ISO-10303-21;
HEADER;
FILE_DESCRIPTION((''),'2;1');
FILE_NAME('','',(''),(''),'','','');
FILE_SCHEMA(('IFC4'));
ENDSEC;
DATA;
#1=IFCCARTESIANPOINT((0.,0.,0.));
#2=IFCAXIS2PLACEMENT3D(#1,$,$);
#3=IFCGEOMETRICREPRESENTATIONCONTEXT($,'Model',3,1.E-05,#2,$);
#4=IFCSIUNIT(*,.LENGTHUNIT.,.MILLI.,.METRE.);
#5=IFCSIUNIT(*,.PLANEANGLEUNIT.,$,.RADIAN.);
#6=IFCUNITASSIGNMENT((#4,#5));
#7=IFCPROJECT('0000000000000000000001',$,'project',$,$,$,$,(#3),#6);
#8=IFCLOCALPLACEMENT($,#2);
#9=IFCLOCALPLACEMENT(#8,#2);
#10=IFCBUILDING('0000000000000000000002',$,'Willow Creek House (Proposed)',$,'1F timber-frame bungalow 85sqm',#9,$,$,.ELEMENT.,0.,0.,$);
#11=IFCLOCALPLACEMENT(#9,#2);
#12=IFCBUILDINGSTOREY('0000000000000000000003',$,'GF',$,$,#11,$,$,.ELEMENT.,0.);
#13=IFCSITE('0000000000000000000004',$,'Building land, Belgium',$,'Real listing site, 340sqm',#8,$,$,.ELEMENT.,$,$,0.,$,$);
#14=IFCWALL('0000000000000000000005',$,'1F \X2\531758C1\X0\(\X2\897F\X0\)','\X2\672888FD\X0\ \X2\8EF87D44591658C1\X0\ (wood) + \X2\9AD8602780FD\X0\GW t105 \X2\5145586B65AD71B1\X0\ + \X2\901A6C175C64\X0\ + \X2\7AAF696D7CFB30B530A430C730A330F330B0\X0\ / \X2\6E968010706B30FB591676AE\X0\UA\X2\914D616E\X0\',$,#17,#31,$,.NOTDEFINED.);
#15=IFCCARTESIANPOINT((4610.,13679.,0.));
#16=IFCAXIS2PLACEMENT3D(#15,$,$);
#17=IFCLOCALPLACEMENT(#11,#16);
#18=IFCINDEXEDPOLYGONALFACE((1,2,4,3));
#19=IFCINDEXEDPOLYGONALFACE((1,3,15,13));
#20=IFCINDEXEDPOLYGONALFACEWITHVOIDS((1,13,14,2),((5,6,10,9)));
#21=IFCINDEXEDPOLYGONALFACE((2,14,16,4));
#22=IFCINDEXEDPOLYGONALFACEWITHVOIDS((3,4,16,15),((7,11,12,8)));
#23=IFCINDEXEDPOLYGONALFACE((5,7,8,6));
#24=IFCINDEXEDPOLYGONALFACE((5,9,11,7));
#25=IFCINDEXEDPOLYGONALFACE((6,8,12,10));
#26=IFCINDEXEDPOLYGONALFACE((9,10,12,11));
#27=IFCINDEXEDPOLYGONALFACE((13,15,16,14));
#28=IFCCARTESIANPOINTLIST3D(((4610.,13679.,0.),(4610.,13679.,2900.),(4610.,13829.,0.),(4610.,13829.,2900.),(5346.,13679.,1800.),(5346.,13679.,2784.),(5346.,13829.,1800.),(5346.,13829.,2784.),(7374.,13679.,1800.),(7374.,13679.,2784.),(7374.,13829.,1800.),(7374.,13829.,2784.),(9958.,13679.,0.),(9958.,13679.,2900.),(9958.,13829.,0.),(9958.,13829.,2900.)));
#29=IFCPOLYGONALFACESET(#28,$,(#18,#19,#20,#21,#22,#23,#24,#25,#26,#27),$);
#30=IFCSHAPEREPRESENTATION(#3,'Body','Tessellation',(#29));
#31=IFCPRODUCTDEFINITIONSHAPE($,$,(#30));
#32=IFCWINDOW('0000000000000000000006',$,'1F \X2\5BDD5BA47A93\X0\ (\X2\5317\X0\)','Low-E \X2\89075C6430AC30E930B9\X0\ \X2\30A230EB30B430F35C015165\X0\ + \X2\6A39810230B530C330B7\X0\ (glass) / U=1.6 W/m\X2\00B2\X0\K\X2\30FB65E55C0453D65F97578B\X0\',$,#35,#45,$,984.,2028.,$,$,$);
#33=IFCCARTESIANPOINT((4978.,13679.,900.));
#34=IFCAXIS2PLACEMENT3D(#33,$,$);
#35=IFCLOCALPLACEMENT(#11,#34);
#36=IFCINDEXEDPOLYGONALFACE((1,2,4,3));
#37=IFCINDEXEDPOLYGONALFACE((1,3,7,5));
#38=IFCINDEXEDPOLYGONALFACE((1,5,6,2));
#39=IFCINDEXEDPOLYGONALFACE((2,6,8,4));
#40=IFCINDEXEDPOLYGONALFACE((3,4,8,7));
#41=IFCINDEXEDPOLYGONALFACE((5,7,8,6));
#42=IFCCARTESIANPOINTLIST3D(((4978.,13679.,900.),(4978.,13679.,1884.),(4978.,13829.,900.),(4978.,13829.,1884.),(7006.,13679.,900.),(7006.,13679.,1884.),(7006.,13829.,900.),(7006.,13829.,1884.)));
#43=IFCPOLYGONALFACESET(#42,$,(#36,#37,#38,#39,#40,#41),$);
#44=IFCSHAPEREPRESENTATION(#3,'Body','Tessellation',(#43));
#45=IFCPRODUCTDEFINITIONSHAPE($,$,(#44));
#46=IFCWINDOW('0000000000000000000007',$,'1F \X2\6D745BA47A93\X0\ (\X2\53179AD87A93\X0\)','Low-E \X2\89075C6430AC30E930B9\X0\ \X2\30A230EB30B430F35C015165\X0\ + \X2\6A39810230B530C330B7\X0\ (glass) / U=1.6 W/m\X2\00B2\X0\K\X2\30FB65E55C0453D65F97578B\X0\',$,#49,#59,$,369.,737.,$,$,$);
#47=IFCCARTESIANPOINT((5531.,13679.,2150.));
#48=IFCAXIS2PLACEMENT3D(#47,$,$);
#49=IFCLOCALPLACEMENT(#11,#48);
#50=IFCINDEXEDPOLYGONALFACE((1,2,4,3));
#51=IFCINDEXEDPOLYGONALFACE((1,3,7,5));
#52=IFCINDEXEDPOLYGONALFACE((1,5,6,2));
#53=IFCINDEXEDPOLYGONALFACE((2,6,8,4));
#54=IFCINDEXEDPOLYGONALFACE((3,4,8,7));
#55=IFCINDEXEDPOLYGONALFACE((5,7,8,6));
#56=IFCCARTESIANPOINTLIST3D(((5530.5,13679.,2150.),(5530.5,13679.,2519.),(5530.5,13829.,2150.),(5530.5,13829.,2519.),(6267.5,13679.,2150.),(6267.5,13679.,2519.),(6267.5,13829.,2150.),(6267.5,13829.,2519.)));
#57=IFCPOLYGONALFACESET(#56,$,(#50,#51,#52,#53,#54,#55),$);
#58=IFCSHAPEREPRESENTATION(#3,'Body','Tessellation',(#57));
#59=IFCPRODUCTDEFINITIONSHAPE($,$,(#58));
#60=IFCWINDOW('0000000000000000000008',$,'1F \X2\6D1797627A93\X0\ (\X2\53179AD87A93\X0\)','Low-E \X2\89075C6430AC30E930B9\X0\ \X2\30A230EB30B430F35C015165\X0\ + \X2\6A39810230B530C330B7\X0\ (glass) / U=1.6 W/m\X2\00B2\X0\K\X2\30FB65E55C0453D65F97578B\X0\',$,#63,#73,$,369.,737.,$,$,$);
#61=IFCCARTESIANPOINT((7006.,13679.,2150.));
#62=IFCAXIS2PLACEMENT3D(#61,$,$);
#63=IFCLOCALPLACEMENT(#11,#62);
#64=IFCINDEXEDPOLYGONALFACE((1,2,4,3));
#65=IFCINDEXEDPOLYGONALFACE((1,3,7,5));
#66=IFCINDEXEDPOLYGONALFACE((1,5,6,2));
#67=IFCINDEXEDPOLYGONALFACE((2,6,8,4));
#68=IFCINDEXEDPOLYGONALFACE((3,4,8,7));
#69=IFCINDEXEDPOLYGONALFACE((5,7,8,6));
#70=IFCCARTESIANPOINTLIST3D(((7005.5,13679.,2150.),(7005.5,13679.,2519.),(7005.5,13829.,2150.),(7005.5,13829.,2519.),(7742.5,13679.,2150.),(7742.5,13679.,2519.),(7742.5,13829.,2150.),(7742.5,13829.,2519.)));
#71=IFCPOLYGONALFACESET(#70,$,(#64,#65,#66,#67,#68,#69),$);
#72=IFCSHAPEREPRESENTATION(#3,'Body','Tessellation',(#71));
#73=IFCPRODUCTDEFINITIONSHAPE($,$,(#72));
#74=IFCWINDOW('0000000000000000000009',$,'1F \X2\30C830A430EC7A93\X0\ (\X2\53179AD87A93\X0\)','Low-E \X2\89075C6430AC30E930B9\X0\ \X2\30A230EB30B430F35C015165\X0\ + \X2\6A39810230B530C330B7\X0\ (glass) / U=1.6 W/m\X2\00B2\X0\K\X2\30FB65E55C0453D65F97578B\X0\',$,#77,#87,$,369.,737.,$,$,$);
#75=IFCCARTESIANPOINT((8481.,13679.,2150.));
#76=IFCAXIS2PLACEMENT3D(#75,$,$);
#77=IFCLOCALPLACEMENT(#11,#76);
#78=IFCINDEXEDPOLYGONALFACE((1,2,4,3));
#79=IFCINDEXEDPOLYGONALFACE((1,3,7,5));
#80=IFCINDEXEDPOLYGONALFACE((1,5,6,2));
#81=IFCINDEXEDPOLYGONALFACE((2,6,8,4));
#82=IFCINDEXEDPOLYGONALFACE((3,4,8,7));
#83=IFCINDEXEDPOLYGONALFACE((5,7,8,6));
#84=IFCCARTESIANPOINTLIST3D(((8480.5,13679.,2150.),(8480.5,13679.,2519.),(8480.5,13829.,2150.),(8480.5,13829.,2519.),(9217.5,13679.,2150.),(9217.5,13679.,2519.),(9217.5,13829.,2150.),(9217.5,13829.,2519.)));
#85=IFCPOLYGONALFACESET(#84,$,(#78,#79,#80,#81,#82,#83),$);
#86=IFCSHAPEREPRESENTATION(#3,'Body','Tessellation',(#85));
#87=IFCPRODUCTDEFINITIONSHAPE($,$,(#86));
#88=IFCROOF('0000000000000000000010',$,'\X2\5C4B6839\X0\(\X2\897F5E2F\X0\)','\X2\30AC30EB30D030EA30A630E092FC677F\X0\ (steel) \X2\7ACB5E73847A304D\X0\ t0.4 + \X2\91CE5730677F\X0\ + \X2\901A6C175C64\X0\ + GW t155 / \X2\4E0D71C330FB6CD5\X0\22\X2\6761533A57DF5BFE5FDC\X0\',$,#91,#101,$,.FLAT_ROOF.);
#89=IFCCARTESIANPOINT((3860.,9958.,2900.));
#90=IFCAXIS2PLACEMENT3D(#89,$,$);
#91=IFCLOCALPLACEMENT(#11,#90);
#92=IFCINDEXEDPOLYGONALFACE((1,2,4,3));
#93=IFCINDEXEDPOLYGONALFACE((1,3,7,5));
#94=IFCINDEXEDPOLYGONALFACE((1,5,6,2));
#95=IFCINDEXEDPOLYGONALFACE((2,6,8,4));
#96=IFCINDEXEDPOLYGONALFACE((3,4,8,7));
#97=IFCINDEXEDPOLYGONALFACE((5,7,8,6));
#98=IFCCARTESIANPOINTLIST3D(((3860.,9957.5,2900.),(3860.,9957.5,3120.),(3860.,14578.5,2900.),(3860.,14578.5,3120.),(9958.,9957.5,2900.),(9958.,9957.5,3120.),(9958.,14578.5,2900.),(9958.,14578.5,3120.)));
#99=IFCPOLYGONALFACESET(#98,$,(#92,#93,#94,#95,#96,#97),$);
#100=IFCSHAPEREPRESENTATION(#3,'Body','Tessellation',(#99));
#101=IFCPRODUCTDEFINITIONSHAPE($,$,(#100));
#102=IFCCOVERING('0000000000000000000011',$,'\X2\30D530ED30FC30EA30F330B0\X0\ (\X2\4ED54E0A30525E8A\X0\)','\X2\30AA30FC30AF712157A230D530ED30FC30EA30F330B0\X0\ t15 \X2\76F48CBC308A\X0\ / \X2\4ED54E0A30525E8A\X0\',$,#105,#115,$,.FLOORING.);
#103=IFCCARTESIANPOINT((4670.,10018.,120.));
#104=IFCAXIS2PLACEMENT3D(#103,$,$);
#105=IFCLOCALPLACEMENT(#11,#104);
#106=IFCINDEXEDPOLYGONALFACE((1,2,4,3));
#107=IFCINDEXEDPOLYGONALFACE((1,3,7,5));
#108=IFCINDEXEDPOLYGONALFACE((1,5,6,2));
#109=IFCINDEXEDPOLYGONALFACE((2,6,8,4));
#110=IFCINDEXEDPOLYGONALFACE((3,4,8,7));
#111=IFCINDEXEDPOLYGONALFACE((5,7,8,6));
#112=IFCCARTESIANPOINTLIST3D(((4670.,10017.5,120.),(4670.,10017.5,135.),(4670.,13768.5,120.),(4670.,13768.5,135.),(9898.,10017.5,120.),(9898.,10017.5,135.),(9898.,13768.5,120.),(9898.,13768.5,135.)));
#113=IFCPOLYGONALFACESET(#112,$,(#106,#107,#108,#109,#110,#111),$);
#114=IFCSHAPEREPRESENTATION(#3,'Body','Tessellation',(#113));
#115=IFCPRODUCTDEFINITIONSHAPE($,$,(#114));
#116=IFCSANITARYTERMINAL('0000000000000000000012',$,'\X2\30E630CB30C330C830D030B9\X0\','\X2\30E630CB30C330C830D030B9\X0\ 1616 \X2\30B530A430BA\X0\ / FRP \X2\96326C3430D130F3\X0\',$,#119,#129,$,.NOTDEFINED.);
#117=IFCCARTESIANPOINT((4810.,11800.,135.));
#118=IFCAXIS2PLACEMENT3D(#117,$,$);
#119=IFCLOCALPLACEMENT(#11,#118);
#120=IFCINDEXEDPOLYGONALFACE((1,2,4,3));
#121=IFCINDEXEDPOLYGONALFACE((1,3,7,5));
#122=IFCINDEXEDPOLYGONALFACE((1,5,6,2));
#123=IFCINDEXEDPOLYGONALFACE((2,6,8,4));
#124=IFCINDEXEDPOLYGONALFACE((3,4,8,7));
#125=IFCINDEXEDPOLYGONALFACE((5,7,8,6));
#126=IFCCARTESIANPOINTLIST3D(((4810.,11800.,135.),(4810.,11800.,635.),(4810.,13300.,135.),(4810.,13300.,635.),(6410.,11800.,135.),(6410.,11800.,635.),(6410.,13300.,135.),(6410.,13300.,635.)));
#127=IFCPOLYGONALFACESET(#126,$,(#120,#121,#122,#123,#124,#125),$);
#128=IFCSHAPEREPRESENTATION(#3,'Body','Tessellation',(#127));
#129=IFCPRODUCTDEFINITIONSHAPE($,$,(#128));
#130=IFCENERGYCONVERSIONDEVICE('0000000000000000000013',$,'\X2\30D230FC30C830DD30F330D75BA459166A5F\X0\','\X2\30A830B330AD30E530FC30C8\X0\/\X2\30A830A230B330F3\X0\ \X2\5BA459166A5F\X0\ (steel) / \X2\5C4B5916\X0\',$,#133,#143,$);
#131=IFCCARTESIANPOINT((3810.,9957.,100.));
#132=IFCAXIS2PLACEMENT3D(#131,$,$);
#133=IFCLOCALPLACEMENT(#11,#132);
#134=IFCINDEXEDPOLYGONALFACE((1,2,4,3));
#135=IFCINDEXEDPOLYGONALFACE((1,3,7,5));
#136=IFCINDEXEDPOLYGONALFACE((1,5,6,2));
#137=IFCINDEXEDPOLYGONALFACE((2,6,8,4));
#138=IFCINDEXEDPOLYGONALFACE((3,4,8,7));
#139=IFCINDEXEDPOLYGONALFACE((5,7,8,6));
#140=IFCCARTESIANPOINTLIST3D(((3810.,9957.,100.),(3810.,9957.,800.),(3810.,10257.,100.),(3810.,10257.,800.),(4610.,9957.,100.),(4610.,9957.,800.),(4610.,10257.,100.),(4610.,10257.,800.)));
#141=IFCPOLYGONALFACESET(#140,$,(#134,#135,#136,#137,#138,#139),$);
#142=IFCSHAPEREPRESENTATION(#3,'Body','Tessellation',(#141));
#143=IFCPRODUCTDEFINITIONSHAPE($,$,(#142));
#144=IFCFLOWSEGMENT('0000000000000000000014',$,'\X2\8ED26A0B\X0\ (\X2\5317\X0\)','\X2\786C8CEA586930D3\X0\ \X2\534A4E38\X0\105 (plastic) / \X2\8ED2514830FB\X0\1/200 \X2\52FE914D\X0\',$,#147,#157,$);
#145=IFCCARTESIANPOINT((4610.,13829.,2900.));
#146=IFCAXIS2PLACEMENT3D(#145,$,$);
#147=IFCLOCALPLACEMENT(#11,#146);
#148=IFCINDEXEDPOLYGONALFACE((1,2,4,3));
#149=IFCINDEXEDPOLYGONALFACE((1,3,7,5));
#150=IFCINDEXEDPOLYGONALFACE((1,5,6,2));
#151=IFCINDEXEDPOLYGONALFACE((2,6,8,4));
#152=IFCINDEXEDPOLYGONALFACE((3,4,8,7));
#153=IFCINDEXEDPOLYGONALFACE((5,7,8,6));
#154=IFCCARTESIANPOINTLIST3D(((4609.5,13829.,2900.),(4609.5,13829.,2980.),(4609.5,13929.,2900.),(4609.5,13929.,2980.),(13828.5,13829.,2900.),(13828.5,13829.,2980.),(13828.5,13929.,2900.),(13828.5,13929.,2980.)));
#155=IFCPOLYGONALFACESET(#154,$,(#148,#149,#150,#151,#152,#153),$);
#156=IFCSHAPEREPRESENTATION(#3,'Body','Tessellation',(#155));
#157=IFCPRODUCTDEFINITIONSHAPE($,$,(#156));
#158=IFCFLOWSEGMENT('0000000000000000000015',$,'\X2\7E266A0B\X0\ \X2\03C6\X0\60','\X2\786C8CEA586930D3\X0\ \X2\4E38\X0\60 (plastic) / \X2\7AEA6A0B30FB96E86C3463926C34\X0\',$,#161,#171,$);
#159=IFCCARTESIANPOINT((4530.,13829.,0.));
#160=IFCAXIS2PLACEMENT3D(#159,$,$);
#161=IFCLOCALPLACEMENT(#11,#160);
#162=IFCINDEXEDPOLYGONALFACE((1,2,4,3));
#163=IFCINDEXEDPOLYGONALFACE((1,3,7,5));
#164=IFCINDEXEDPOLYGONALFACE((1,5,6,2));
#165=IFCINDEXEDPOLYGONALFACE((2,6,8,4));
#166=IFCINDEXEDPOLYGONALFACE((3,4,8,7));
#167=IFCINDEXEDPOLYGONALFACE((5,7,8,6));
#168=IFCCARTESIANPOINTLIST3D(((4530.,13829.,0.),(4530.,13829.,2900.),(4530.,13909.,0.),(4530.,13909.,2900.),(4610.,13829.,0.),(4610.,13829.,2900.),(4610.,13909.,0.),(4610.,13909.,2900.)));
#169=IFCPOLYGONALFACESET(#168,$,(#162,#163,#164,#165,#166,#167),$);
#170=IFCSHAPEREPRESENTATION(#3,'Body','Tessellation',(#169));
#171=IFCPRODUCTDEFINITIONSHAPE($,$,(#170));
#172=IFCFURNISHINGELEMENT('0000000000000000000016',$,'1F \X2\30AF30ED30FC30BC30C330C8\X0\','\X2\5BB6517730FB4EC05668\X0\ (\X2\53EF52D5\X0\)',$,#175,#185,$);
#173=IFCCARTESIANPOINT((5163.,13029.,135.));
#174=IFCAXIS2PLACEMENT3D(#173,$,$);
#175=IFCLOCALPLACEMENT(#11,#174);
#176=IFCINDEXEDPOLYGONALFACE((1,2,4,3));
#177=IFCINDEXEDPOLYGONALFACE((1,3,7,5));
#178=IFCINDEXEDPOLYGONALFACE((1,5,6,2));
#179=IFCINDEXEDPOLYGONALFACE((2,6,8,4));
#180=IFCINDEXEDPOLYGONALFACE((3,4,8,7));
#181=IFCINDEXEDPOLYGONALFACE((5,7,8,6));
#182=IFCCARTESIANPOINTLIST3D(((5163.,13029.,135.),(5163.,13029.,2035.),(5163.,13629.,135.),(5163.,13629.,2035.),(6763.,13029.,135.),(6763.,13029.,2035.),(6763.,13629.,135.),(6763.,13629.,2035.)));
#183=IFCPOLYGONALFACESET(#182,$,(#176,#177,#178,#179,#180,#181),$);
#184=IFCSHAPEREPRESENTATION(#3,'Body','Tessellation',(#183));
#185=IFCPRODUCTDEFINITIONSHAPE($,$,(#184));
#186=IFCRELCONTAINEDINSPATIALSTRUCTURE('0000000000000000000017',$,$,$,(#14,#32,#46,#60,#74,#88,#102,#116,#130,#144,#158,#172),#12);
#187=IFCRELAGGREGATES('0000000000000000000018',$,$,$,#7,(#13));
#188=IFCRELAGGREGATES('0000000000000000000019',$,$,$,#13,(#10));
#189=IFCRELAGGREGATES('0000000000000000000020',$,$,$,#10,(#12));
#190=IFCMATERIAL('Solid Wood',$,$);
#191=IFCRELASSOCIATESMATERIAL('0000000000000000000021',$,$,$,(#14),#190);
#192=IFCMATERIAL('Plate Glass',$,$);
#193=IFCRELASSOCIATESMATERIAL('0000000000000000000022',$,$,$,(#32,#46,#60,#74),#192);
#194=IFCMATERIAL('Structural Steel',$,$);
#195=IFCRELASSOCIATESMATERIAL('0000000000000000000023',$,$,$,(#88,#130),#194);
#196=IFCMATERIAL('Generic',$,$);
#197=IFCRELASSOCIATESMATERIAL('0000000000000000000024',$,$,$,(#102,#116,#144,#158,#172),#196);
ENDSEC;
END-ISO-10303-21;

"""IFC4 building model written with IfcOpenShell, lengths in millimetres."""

from ifc_helpers import new_model, si_unit, frame, frame_2d, origin, place, context, project, spatial, rectangle, extrude, material, element, fill, save


model = new_model("IFC4")

# Units and contexts
model_context = context("Model", 3, precision=1e-05, world=origin())
ifc_project = project(units=[si_unit("LENGTHUNIT", "METRE", prefix="MILLI"), si_unit("PLANEANGLEUNIT", "RADIAN")], contexts=[model_context])

# Site, building, storey
site_placement = place(None, origin())
site = spatial("IfcSite", under=ifc_project, at=site_placement, Name="Building land, Belgium", ObjectType="Real listing site, 340sqm", CompositionType="ELEMENT", RefElevation=0.0)
building_placement = place(site_placement, origin())
building = spatial("IfcBuilding", under=site, at=building_placement, Name="Willow Creek House (Proposed)", ObjectType="1F timber-frame bungalow 85sqm", CompositionType="ELEMENT", ElevationOfRefHeight=0.0, ElevationOfTerrain=0.0)
storey_placement = place(building_placement, origin())
storey = spatial("IfcBuildingStorey", under=building, at=storey_placement, Name="GF", CompositionType="ELEMENT", Elevation=0.0)

# Shared definitions
ifc_material_1 = material(Name="Solid Wood")

# Wall, openings, windows
wall_1_placement = place(storey_placement, frame((4610.0, 13679.0, 0.0)))
wall_1 = element("IfcWall", 1, at=wall_1_placement, inside=storey, material=ifc_material_1, Name="1F 北壁(西)", Description="木製 軸組外壁 (wood) + 高性能GW t105 充填断熱 + 通気層 + 窯業系サイディング / 準耐火・外皮UA配慮", PredefinedType="NOTDEFINED", context=model_context, shape_type="SweptSolid", body=[
    extrude(rectangle(XDim=5348.0, YDim=150.0, at=frame_2d((2674.0, 75.0))), frame((4610.0, 13679.0, 0.0)), (0.0, 0.0, 1.0), 2900.0),
])
opening_1_placement = place(storey_placement, frame((4978.0, 13679.0, 900.0)))
opening_1 = element("IfcOpeningElement", 2, at=opening_1_placement, cuts=wall_1, PredefinedType="NOTDEFINED", context=model_context, shape_type="SweptSolid", body=[
    extrude(rectangle(XDim=2028.0, YDim=150.0, at=frame_2d((1014.0, 75.0))), frame((4978.0, 13679.0, 900.0)), (0.0, 0.0, 1.0), 984.0),
])
opening_2_placement = place(storey_placement, frame((5531.0, 13679.0, 2150.0)))
opening_2 = element("IfcOpeningElement", 3, at=opening_2_placement, cuts=wall_1, PredefinedType="NOTDEFINED", context=model_context, shape_type="SweptSolid", body=[
    extrude(rectangle(XDim=737.0, YDim=150.0, at=frame_2d((368.0, 75.0))), frame((5531.0, 13679.0, 2150.0)), (0.0, 0.0, 1.0), 369.0),
])
opening_3_placement = place(storey_placement, frame((7006.0, 13679.0, 2150.0)))
opening_3 = element("IfcOpeningElement", 4, at=opening_3_placement, cuts=wall_1, PredefinedType="NOTDEFINED", context=model_context, shape_type="SweptSolid", body=[
    extrude(rectangle(XDim=737.0, YDim=150.0, at=frame_2d((368.0, 75.0))), frame((7006.0, 13679.0, 2150.0)), (0.0, 0.0, 1.0), 369.0),
])
opening_4_placement = place(storey_placement, frame((8481.0, 13679.0, 2150.0)))
opening_4 = element("IfcOpeningElement", 5, at=opening_4_placement, cuts=wall_1, PredefinedType="NOTDEFINED", context=model_context, shape_type="SweptSolid", body=[
    extrude(rectangle(XDim=737.0, YDim=150.0, at=frame_2d((368.0, 75.0))), frame((8481.0, 13679.0, 2150.0)), (0.0, 0.0, 1.0), 369.0),
])
ifc_material_2 = material(Name="Plate Glass")
window_1_placement = place(storey_placement, frame((4978.0, 13679.0, 900.0)))
window_1 = element("IfcWindow", 6, at=window_1_placement, inside=storey, material=ifc_material_2, Name="1F 寝室窓 (北)", Description="Low-E 複層ガラス アルゴン封入 + 樹脂サッシ (glass) / U=1.6 W/m²K・日射取得型", OverallHeight=984.0, OverallWidth=2028.0, context=model_context, shape_type="SweptSolid", body=[
    extrude(rectangle(XDim=2028.0, YDim=150.0, at=frame_2d((1014.0, 75.0))), frame((4978.0, 13679.0, 900.0)), (0.0, 0.0, 1.0), 984.0),
])
fill(opening_1, window_1)
window_2_placement = place(storey_placement, frame((5531.0, 13679.0, 2150.0)))
window_2 = element("IfcWindow", 7, at=window_2_placement, inside=storey, material=ifc_material_2, Name="1F 浴室窓 (北高窓)", Description="Low-E 複層ガラス アルゴン封入 + 樹脂サッシ (glass) / U=1.6 W/m²K・日射取得型", OverallHeight=369.0, OverallWidth=737.0, context=model_context, shape_type="SweptSolid", body=[
    extrude(rectangle(XDim=737.0, YDim=150.0, at=frame_2d((368.0, 75.0))), frame((5531.0, 13679.0, 2150.0)), (0.0, 0.0, 1.0), 369.0),
])
fill(opening_2, window_2)
window_3_placement = place(storey_placement, frame((7006.0, 13679.0, 2150.0)))
window_3 = element("IfcWindow", 8, at=window_3_placement, inside=storey, material=ifc_material_2, Name="1F 洗面窓 (北高窓)", Description="Low-E 複層ガラス アルゴン封入 + 樹脂サッシ (glass) / U=1.6 W/m²K・日射取得型", OverallHeight=369.0, OverallWidth=737.0, context=model_context, shape_type="SweptSolid", body=[
    extrude(rectangle(XDim=737.0, YDim=150.0, at=frame_2d((368.0, 75.0))), frame((7006.0, 13679.0, 2150.0)), (0.0, 0.0, 1.0), 369.0),
])
fill(opening_3, window_3)
window_4_placement = place(storey_placement, frame((8481.0, 13679.0, 2150.0)))
window_4 = element("IfcWindow", 9, at=window_4_placement, inside=storey, material=ifc_material_2, Name="1F トイレ窓 (北高窓)", Description="Low-E 複層ガラス アルゴン封入 + 樹脂サッシ (glass) / U=1.6 W/m²K・日射取得型", OverallHeight=369.0, OverallWidth=737.0, context=model_context, shape_type="SweptSolid", body=[
    extrude(rectangle(XDim=737.0, YDim=150.0, at=frame_2d((368.0, 75.0))), frame((8481.0, 13679.0, 2150.0)), (0.0, 0.0, 1.0), 369.0),
])
fill(opening_4, window_4)

# Roof
ifc_material_3 = material(Name="Structural Steel")
roof_placement = place(storey_placement, frame((3860.0, 9958.0, 2900.0)))
element("IfcRoof", 10, at=roof_placement, inside=storey, material=ifc_material_3, Name="屋根(西帯)", Description="ガルバリウム鋼板 (steel) 立平葺き t0.4 + 野地板 + 通気層 + GW t155 / 不燃・法22条区域対応", PredefinedType="FLAT_ROOF", context=model_context, shape_type="SweptSolid", body=[
    extrude(rectangle(XDim=6098.0, YDim=4621.0, at=frame_2d((3049.0, 2310.0))), frame((3860.0, 9958.0, 2900.0)), (0.0, 0.0, 1.0), 220.0),
])

# Covering
ifc_material_4 = material(Name="Generic")
covering_placement = place(storey_placement, frame((4670.0, 10018.0, 120.0)))
element("IfcCovering", 11, at=covering_placement, inside=storey, material=ifc_material_4, Name="フローリング (仕上げ床)", Description="オーク無垢フローリング t15 直貼り / 仕上げ床", PredefinedType="FLOORING", context=model_context, shape_type="SweptSolid", body=[
    extrude(rectangle(XDim=5228.0, YDim=3751.0, at=frame_2d((2614.0, 1875.0))), frame((4670.0, 10018.0, 120.0)), (0.0, 0.0, 1.0), 15.0),
])

# Sanitary terminal
sanitary_terminal_placement = place(storey_placement, frame((4810.0, 11800.0, 135.0)))
element("IfcSanitaryTerminal", 12, at=sanitary_terminal_placement, inside=storey, material=ifc_material_4, Name="ユニットバス", Description="ユニットバス 1616 サイズ / FRP 防水パン", PredefinedType="NOTDEFINED", context=model_context, shape_type="SweptSolid", body=[
    extrude(rectangle(XDim=1600.0, YDim=1500.0, at=frame_2d((800.0, 750.0))), frame((4810.0, 11800.0, 135.0)), (0.0, 0.0, 1.0), 500.0),
])

# Energy conversion device
energy_conversion_device_placement = place(storey_placement, frame((3810.0, 9957.0, 100.0)))
element("IfcEnergyConversionDevice", 13, at=energy_conversion_device_placement, inside=storey, material=ifc_material_3, Name="ヒートポンプ室外機", Description="エコキュート/エアコン 室外機 (steel) / 屋外", context=model_context, shape_type="SweptSolid", body=[
    extrude(rectangle(XDim=800.0, YDim=300.0, at=frame_2d((400.0, 150.0))), frame((3810.0, 9957.0, 100.0)), (0.0, 0.0, 1.0), 700.0),
])

# Flow segments
flow_segment_1_placement = place(storey_placement, frame((4610.0, 13829.0, 2900.0)))
element("IfcFlowSegment", 14, at=flow_segment_1_placement, inside=storey, material=ifc_material_4, Name="軒樋 (北)", Description="硬質塩ビ 半丸105 (plastic) / 軒先・1/200 勾配", context=model_context, shape_type="SweptSolid", body=[
    extrude(rectangle(XDim=9219.0, YDim=100.0, at=frame_2d((4609.0, 50.0))), frame((4610.0, 13829.0, 2900.0)), (0.0, 0.0, 1.0), 80.0),
])
flow_segment_2_placement = place(storey_placement, frame((4530.0, 13829.0, 0.0)))
element("IfcFlowSegment", 15, at=flow_segment_2_placement, inside=storey, material=ifc_material_4, Name="縦樋 φ60", Description="硬質塩ビ 丸60 (plastic) / 竪樋・雨水排水", context=model_context, shape_type="SweptSolid", body=[
    extrude(rectangle(XDim=80.0, YDim=80.0, at=frame_2d((40.0, 40.0))), frame((4530.0, 13829.0, 0.0)), (0.0, 0.0, 1.0), 2900.0),
])

# Furnishing element
furnishing_1_placement = place(storey_placement, frame((5163.0, 13029.0, 135.0)))
element("IfcFurnishingElement", 16, at=furnishing_1_placement, inside=storey, material=ifc_material_4, Name="1F クローゼット", Description="家具・什器 (可動)", context=model_context, shape_type="SweptSolid", body=[
    extrude(rectangle(XDim=1600.0, YDim=600.0, at=frame_2d((800.0, 300.0))), frame((5163.0, 13029.0, 135.0)), (0.0, 0.0, 1.0), 1900.0),
])

save(model, "model.ifc")
